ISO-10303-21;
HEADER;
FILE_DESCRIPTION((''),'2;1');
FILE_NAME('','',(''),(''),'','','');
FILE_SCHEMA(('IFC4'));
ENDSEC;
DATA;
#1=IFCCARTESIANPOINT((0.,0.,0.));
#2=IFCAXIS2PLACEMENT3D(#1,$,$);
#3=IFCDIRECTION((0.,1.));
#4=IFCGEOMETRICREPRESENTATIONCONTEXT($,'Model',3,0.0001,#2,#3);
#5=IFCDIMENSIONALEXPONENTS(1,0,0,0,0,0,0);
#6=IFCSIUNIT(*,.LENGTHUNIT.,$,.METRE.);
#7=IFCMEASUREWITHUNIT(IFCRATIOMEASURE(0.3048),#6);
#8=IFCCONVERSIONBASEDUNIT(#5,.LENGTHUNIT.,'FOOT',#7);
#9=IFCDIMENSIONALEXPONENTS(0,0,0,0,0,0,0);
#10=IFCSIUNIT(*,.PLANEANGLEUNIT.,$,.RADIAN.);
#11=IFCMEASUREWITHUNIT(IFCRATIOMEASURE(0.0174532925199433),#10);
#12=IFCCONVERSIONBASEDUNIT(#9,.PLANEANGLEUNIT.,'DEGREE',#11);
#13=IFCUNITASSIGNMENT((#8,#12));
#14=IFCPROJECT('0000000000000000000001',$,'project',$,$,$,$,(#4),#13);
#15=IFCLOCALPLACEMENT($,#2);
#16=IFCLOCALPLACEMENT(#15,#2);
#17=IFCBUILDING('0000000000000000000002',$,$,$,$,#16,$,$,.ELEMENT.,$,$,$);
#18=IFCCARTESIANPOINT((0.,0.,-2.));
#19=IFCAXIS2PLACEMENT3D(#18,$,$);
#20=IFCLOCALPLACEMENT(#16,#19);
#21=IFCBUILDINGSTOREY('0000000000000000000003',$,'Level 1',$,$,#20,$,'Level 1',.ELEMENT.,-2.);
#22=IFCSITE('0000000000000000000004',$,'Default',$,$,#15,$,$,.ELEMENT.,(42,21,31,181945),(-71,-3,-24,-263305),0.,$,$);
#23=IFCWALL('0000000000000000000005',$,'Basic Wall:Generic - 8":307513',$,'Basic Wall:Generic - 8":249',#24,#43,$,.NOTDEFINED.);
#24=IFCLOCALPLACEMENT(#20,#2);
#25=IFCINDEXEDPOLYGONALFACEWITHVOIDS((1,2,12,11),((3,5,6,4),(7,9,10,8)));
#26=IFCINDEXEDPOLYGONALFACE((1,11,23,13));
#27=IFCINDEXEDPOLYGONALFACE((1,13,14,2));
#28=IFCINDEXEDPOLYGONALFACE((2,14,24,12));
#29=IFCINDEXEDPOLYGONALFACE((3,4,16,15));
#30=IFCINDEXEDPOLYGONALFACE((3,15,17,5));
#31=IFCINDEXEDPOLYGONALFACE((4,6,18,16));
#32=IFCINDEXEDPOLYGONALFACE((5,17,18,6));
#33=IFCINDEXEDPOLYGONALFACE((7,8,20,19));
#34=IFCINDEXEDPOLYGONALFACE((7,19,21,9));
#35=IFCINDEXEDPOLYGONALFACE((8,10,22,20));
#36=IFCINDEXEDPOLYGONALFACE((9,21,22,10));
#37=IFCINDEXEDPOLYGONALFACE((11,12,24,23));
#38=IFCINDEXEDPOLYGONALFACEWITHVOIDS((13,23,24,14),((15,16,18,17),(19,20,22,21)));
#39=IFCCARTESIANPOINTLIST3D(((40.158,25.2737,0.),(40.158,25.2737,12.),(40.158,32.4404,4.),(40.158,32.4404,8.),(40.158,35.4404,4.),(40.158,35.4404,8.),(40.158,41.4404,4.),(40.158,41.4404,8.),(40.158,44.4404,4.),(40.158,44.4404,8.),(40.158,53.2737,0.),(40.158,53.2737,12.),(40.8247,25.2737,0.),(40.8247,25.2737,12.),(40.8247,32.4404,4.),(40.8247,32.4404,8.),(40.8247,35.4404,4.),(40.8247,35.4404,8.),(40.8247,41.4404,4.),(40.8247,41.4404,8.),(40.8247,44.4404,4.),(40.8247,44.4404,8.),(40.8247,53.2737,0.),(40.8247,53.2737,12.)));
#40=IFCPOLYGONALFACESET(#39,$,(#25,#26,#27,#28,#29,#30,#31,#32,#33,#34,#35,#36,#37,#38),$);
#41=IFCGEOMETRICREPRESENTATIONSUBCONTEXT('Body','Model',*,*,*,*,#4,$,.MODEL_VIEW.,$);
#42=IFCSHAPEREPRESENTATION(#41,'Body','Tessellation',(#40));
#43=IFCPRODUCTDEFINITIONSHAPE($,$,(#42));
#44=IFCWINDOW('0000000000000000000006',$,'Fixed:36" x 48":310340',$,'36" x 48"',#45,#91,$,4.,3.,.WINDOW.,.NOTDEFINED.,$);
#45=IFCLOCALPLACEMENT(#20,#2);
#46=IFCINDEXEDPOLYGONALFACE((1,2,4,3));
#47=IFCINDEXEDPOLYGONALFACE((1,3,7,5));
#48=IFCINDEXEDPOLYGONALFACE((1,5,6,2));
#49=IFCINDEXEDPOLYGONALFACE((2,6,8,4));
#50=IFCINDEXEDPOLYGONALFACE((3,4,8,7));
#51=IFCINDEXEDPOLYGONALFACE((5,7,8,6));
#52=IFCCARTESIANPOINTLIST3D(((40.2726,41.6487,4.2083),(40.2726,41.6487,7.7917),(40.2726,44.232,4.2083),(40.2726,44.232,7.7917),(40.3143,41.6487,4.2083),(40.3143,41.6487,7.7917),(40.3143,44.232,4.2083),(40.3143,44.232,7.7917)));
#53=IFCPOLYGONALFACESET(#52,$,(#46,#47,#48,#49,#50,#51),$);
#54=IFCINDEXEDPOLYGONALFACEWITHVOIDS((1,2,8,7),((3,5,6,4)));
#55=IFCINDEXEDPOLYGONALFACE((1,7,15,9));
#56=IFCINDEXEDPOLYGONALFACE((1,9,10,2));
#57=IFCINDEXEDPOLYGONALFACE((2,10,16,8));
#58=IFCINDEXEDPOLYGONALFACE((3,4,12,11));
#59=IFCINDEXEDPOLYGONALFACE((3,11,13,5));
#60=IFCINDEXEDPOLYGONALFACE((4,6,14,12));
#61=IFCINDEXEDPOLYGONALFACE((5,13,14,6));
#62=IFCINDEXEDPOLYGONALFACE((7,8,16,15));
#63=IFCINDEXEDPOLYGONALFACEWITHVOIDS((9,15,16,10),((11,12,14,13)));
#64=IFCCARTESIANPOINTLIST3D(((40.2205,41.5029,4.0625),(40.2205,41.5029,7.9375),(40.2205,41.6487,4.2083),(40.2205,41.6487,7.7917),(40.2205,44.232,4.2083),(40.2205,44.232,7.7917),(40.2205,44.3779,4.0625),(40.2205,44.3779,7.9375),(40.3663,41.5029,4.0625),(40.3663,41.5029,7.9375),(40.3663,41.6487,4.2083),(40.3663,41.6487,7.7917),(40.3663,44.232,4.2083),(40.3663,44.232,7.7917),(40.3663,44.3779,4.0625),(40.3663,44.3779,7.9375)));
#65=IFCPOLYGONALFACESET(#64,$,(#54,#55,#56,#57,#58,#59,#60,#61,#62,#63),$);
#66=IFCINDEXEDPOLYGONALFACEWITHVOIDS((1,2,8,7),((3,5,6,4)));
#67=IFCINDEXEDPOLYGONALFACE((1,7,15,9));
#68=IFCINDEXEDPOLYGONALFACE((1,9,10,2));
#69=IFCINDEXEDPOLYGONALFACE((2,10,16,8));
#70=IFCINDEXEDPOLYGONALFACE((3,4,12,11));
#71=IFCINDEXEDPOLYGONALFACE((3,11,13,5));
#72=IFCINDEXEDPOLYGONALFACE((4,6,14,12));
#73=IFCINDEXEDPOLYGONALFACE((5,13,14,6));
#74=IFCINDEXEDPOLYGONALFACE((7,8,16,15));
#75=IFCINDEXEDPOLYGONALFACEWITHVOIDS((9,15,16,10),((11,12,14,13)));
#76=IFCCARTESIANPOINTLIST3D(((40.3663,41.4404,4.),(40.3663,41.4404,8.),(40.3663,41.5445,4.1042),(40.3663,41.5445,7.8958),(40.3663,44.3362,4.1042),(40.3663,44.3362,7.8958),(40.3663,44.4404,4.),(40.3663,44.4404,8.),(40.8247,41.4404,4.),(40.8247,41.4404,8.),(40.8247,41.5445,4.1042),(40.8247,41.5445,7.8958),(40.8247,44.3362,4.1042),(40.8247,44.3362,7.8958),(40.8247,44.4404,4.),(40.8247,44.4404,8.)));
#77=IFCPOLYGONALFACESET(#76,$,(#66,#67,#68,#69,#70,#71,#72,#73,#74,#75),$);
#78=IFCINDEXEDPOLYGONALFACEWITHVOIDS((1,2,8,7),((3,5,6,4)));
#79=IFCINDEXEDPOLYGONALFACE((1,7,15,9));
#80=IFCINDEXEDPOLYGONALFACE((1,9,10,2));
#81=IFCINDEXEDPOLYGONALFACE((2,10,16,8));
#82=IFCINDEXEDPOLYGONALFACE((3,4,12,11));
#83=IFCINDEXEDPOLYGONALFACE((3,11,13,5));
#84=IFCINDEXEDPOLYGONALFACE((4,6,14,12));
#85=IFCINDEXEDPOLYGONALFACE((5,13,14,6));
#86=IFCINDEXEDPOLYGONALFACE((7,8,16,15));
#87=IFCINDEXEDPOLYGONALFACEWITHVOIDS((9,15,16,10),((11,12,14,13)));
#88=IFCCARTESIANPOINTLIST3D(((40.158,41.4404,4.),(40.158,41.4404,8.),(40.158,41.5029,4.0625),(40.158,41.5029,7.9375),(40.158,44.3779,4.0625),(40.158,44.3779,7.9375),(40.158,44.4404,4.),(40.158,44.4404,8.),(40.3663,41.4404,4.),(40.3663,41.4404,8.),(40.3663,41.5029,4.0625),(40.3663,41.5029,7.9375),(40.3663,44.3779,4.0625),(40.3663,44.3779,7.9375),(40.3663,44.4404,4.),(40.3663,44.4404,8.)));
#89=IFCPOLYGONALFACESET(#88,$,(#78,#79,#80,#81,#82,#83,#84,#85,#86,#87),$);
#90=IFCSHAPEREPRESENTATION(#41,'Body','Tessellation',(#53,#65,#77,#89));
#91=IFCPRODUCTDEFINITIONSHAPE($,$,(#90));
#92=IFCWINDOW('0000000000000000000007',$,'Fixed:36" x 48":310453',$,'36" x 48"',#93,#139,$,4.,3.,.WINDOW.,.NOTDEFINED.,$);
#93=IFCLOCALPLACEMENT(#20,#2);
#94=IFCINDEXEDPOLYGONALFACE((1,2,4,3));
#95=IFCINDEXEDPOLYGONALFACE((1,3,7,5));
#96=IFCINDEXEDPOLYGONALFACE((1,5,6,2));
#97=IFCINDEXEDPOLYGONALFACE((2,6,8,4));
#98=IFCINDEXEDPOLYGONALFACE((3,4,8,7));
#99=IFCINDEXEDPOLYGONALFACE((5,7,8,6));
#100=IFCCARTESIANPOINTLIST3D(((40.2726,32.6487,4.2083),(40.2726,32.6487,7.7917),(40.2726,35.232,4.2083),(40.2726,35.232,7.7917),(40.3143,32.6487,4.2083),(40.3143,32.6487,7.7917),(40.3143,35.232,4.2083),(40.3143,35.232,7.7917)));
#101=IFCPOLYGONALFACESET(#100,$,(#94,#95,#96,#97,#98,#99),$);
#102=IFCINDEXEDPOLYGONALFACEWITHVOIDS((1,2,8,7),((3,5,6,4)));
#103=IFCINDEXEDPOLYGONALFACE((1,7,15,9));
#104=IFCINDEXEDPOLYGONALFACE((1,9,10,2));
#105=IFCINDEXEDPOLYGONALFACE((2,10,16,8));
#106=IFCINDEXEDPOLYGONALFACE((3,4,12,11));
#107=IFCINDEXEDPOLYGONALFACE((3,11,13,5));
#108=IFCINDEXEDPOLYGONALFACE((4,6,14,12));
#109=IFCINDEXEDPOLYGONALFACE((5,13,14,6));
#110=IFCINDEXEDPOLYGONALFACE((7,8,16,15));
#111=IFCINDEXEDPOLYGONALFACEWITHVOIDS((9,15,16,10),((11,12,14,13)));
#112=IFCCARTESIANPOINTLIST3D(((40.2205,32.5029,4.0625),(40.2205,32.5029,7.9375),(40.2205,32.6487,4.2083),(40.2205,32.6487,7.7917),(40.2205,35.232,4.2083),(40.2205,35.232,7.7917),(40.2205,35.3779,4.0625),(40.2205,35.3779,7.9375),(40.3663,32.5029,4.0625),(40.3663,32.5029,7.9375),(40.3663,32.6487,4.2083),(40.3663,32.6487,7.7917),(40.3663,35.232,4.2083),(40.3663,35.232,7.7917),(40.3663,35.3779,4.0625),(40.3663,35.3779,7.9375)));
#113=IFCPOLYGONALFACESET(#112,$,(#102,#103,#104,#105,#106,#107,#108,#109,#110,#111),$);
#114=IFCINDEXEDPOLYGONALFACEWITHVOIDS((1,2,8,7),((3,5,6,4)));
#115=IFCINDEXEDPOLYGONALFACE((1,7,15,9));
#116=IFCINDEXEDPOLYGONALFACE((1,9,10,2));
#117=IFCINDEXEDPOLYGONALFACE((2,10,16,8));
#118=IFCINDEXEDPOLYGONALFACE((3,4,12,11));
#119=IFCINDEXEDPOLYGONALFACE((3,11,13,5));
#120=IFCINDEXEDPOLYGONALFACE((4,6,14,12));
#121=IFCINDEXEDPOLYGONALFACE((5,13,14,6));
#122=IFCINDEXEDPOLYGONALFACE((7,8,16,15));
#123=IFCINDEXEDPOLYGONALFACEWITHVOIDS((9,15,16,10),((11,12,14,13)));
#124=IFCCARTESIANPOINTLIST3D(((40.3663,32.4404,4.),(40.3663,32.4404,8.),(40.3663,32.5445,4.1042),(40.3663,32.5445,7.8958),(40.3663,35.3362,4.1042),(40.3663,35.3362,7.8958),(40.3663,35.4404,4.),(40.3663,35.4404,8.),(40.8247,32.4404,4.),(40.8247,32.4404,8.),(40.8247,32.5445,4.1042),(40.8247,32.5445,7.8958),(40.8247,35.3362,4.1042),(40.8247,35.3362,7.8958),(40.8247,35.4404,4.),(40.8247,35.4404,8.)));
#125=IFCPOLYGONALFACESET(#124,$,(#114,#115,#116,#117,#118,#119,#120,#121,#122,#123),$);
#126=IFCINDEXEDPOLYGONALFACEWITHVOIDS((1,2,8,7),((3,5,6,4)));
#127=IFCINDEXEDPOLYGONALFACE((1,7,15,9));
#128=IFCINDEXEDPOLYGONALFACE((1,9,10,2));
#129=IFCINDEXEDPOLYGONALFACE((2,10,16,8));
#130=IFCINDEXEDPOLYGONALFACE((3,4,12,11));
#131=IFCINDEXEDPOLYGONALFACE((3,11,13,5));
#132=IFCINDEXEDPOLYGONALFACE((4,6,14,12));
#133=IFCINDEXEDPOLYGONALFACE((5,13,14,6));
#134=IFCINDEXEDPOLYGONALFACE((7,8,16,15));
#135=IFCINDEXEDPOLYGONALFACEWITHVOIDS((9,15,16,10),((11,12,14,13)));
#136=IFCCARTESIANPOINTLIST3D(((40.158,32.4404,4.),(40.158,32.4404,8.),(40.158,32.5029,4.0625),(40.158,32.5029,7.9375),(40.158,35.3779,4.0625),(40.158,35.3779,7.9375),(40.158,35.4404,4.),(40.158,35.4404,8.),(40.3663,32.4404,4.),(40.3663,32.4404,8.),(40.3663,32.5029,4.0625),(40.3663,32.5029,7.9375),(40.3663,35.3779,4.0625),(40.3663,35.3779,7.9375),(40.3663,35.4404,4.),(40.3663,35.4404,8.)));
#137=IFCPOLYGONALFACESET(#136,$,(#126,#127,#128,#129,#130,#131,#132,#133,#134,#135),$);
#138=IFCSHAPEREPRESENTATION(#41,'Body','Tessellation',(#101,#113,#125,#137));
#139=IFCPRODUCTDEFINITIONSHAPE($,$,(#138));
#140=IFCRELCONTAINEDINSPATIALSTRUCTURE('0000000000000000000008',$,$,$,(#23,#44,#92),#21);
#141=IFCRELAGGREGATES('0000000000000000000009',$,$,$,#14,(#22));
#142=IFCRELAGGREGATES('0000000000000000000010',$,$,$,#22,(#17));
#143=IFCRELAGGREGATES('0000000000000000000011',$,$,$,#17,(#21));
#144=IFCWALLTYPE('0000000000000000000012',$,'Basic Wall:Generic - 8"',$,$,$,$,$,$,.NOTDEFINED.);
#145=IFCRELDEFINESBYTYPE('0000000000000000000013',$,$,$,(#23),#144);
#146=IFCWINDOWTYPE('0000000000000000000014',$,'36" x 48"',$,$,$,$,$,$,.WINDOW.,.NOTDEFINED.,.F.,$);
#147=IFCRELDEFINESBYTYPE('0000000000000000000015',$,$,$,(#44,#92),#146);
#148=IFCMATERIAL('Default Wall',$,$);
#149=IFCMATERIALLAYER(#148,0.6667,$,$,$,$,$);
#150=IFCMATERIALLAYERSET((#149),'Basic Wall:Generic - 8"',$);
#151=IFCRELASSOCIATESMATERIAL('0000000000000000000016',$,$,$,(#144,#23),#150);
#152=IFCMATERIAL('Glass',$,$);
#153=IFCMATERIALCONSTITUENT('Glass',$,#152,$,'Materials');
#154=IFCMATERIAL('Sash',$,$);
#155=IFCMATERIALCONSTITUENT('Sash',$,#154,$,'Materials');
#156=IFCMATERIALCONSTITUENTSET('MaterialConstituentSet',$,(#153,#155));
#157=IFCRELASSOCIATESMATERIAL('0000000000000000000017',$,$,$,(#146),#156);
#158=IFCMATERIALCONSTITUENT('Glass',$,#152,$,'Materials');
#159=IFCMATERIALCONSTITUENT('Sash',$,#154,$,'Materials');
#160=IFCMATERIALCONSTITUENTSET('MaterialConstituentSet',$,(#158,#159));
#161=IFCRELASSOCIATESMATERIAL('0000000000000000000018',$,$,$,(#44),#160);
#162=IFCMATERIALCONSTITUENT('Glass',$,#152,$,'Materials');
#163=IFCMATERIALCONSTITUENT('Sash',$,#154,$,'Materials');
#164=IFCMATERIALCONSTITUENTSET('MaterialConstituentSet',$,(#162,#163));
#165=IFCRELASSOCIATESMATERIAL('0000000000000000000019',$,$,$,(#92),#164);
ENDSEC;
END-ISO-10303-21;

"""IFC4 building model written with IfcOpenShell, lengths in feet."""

from ifc_helpers import new_model, entity, si_unit, converted_unit, direction, frame, frame_2d, origin, place, context, subcontext, project, spatial, polyline, rectangle, outline, extrude, source, transform, mapped, material, layer, layer_set, layer_usage, constituent, constituent_set, type_object, type_shapes, element, fill, save


model = new_model("IFC4")

# Units and contexts
model_context = context("Model", 3, precision=0.0001, world=origin(), true_north=direction((0.0, 1.0)))
body_context = subcontext(model_context, "Body", "Model", "MODEL_VIEW")
ifc_project = project(units=[converted_unit("LENGTHUNIT", "FOOT", entity("IfcRatioMeasure", 0.3048), si_unit("LENGTHUNIT", "METRE"), dimensions=[1, 0, 0, 0, 0, 0, 0]), converted_unit("PLANEANGLEUNIT", "DEGREE", entity("IfcRatioMeasure", 0.0174532925199433), si_unit("PLANEANGLEUNIT", "RADIAN"), dimensions=[0, 0, 0, 0, 0, 0, 0])], contexts=[model_context])

# Site, building, storey
site_placement = place(None, origin())
site = spatial("IfcSite", under=ifc_project, at=site_placement, Name="Default", CompositionType="ELEMENT", RefLatitude=(42, 21, 31, 181945), RefLongitude=(-71, -3, -24, -263305), RefElevation=0.0)
building_placement = place(site_placement, origin())
building = spatial("IfcBuilding", under=site, at=building_placement, CompositionType="ELEMENT")
storey_placement = place(building_placement, frame((0.0, 0.0, -2.0)))
storey = spatial("IfcBuildingStorey", under=building, at=storey_placement, Name="Level 1", LongName="Level 1", CompositionType="ELEMENT", Elevation=-2.0)

# Wall, openings, windows
ifc_material_1 = material(Name="Default Wall")
ifc_layer = layer(ifc_material_1, 0.6667)
ifc_layer_set = layer_set([ifc_layer], Name="Basic Wall:Generic - 8\"")
wall_type = type_object("IfcWallType", Name="Basic Wall:Generic - 8\"", PredefinedType="NOTDEFINED", material=ifc_layer_set)
ifc_material_2 = material(Name="Glass")
ifc_material_3 = material(Name="Sash")
ifc_layer_usage_1 = layer_usage(ifc_layer_set, "AXIS2", "NEGATIVE", 0.3333)
wall_1_placement = place(storey_placement, frame((40.4913, 53.2737, 0.0), z_axis=(0.0, 0.0, 1.0), x_axis=(0.0, -1.0, 0.0)))
wall_1 = element("IfcWall", 1, at=wall_1_placement, inside=storey, type_object=wall_type, material=ifc_layer_usage_1, Name="Basic Wall:Generic - 8\":307513", ObjectType="Basic Wall:Generic - 8\":249", PredefinedType="NOTDEFINED", context=body_context, shape_type="SweptSolid", body=[
    extrude(rectangle(XDim=28.0, YDim=0.6667, at=frame_2d((14.0, 0.0), x_axis=(-1.0, 0.0))), origin(), (0.0, 0.0, 1.0), 12.0),
])
opening_1_placement = place(wall_1_placement, frame((11.8333, 0.3333, 4.0)))
opening_1 = element("IfcOpeningElement", 2, at=opening_1_placement, cuts=wall_1, ObjectType="Opening", PredefinedType="OPENING", context=body_context, shape_type="SweptSolid", body=[
    extrude(rectangle(XDim=4.0, YDim=3.0, at=frame_2d((2.0, 1.5), x_axis=(-1.0, 0.0))), frame((0.0, 0.0, 0.0), z_axis=(0.0, -1.0, 0.0), x_axis=(0.0, 0.0, 1.0)), (0.0, 0.0, 1.0), 0.6667),
])
opening_2_placement = place(wall_1_placement, frame((20.8333, 0.3333, 4.0)))
opening_2 = element("IfcOpeningElement", 3, at=opening_2_placement, cuts=wall_1, ObjectType="Opening", PredefinedType="OPENING", context=body_context, shape_type="SweptSolid", body=[
    extrude(rectangle(XDim=4.0, YDim=3.0, at=frame_2d((2.0, 1.5), x_axis=(-1.0, 0.0))), frame((0.0, 0.0, 0.0), z_axis=(0.0, -1.0, 0.0), x_axis=(0.0, 0.0, 1.0)), (0.0, 0.0, 1.0), 0.6667),
])
ifc_constituent_1 = constituent(ifc_material_2, Name="Glass", Category="Materials")
ifc_constituent_2 = constituent(ifc_material_3, Name="Sash", Category="Materials")
ifc_constituent_set_1 = constituent_set(constituents=[ifc_constituent_1, ifc_constituent_2], Name="MaterialConstituentSet")
ifc_constituent_3 = constituent(ifc_material_2, Name="Glass", Category="Materials")
ifc_constituent_4 = constituent(ifc_material_3, Name="Sash", Category="Materials")
ifc_constituent_set_2 = constituent_set(constituents=[ifc_constituent_3, ifc_constituent_4], Name="MaterialConstituentSet")
window_type_1 = type_object("IfcWindowType", Name="36\" x 48\"", ParameterTakesPrecedence=False, PartitioningType="NOTDEFINED", PredefinedType="WINDOW", material=ifc_constituent_set_2)
shared_shape_1 = source(origin(), body_context, "Body", "SweptSolid", [
    extrude(rectangle(XDim=0.0417, YDim=2.5833, at=frame_2d((0.0, 0.0), x_axis=(1.0, 0.0))), frame((1.5, 0.5312, 0.2083), z_axis=(0.0, 0.0, 1.0), x_axis=(0.0, 1.0, 0.0)), (0.0, 0.0, 1.0), 3.5833),
    extrude(outline(polyline([(-1.4375, -1.9375), (1.4375, -1.9375), (1.4375, 1.9375), (-1.4375, 1.9375), (-1.4375, -1.9375)]), holes=[polyline([(-1.2917, -1.7917), (-1.2917, 1.7917), (1.2917, 1.7917), (1.2917, -1.7917), (-1.2917, -1.7917)])]), frame((1.5, 0.4583, 2.0), z_axis=(0.0, 1.0, 0.0), x_axis=(1.0, 0.0, 0.0)), (0.0, 0.0, 1.0), 0.1458),
    extrude(outline(polyline([(-1.5, -2.0), (1.5, -2.0), (1.5, 2.0), (-1.5, 2.0), (-1.5, -2.0)]), holes=[polyline([(-1.3958, -1.8958), (-1.3958, 1.8958), (1.3958, 1.8958), (1.3958, -1.8958), (-1.3958, -1.8958)])]), frame((1.5, 0.0, 2.0), z_axis=(0.0, 1.0, 0.0), x_axis=(1.0, 0.0, 0.0)), (0.0, 0.0, 1.0), 0.4583),
    extrude(outline(polyline([(-2.0, -1.5), (2.0, -1.5), (2.0, 1.5), (-2.0, 1.5), (-2.0, -1.5)]), holes=[polyline([(-1.9375, -1.4375), (-1.9375, 1.4375), (1.9375, 1.4375), (1.9375, -1.4375), (-1.9375, -1.4375)])]), frame((1.5, 0.4583, 2.0), z_axis=(0.0, 1.0, 0.0), x_axis=(0.0, 0.0, -1.0)), (0.0, 0.0, 1.0), 0.2083),
])
type_shapes(window_type_1, [shared_shape_1])
window_1_placement = place(opening_1_placement, frame((0.0, 0.0, 0.0), z_axis=(0.0, 0.0, 1.0), x_axis=(-1.0, 0.0, 0.0)))
window_1 = element("IfcWindow", 4, at=window_1_placement, inside=storey, type_object=window_type_1, material=ifc_constituent_set_1, Name="Fixed:36\" x 48\":310340", ObjectType="36\" x 48\"", OverallHeight=4.0, OverallWidth=3.0, PartitioningType="NOTDEFINED", PredefinedType="WINDOW", context=body_context, shape_type="MappedRepresentation", body=[
    mapped(shared_shape_1, transform((0.0, 0.0, 0.0), scale=1.0)),
])
fill(opening_1, window_1)
ifc_constituent_5 = constituent(ifc_material_2, Name="Glass", Category="Materials")
ifc_constituent_6 = constituent(ifc_material_3, Name="Sash", Category="Materials")
ifc_constituent_set_3 = constituent_set(constituents=[ifc_constituent_5, ifc_constituent_6], Name="MaterialConstituentSet")
window_2_placement = place(opening_2_placement, frame((0.0, 0.0, 0.0), z_axis=(0.0, 0.0, 1.0), x_axis=(-1.0, 0.0, 0.0)))
window_2 = element("IfcWindow", 5, at=window_2_placement, inside=storey, type_object=window_type_1, material=ifc_constituent_set_3, Name="Fixed:36\" x 48\":310453", ObjectType="36\" x 48\"", OverallHeight=4.0, OverallWidth=3.0, PartitioningType="NOTDEFINED", PredefinedType="WINDOW", context=body_context, shape_type="MappedRepresentation", body=[
    mapped(shared_shape_1, transform((0.0, 0.0, 0.0), scale=1.0)),
])
fill(opening_2, window_2)

save(model, "model.ifc")
